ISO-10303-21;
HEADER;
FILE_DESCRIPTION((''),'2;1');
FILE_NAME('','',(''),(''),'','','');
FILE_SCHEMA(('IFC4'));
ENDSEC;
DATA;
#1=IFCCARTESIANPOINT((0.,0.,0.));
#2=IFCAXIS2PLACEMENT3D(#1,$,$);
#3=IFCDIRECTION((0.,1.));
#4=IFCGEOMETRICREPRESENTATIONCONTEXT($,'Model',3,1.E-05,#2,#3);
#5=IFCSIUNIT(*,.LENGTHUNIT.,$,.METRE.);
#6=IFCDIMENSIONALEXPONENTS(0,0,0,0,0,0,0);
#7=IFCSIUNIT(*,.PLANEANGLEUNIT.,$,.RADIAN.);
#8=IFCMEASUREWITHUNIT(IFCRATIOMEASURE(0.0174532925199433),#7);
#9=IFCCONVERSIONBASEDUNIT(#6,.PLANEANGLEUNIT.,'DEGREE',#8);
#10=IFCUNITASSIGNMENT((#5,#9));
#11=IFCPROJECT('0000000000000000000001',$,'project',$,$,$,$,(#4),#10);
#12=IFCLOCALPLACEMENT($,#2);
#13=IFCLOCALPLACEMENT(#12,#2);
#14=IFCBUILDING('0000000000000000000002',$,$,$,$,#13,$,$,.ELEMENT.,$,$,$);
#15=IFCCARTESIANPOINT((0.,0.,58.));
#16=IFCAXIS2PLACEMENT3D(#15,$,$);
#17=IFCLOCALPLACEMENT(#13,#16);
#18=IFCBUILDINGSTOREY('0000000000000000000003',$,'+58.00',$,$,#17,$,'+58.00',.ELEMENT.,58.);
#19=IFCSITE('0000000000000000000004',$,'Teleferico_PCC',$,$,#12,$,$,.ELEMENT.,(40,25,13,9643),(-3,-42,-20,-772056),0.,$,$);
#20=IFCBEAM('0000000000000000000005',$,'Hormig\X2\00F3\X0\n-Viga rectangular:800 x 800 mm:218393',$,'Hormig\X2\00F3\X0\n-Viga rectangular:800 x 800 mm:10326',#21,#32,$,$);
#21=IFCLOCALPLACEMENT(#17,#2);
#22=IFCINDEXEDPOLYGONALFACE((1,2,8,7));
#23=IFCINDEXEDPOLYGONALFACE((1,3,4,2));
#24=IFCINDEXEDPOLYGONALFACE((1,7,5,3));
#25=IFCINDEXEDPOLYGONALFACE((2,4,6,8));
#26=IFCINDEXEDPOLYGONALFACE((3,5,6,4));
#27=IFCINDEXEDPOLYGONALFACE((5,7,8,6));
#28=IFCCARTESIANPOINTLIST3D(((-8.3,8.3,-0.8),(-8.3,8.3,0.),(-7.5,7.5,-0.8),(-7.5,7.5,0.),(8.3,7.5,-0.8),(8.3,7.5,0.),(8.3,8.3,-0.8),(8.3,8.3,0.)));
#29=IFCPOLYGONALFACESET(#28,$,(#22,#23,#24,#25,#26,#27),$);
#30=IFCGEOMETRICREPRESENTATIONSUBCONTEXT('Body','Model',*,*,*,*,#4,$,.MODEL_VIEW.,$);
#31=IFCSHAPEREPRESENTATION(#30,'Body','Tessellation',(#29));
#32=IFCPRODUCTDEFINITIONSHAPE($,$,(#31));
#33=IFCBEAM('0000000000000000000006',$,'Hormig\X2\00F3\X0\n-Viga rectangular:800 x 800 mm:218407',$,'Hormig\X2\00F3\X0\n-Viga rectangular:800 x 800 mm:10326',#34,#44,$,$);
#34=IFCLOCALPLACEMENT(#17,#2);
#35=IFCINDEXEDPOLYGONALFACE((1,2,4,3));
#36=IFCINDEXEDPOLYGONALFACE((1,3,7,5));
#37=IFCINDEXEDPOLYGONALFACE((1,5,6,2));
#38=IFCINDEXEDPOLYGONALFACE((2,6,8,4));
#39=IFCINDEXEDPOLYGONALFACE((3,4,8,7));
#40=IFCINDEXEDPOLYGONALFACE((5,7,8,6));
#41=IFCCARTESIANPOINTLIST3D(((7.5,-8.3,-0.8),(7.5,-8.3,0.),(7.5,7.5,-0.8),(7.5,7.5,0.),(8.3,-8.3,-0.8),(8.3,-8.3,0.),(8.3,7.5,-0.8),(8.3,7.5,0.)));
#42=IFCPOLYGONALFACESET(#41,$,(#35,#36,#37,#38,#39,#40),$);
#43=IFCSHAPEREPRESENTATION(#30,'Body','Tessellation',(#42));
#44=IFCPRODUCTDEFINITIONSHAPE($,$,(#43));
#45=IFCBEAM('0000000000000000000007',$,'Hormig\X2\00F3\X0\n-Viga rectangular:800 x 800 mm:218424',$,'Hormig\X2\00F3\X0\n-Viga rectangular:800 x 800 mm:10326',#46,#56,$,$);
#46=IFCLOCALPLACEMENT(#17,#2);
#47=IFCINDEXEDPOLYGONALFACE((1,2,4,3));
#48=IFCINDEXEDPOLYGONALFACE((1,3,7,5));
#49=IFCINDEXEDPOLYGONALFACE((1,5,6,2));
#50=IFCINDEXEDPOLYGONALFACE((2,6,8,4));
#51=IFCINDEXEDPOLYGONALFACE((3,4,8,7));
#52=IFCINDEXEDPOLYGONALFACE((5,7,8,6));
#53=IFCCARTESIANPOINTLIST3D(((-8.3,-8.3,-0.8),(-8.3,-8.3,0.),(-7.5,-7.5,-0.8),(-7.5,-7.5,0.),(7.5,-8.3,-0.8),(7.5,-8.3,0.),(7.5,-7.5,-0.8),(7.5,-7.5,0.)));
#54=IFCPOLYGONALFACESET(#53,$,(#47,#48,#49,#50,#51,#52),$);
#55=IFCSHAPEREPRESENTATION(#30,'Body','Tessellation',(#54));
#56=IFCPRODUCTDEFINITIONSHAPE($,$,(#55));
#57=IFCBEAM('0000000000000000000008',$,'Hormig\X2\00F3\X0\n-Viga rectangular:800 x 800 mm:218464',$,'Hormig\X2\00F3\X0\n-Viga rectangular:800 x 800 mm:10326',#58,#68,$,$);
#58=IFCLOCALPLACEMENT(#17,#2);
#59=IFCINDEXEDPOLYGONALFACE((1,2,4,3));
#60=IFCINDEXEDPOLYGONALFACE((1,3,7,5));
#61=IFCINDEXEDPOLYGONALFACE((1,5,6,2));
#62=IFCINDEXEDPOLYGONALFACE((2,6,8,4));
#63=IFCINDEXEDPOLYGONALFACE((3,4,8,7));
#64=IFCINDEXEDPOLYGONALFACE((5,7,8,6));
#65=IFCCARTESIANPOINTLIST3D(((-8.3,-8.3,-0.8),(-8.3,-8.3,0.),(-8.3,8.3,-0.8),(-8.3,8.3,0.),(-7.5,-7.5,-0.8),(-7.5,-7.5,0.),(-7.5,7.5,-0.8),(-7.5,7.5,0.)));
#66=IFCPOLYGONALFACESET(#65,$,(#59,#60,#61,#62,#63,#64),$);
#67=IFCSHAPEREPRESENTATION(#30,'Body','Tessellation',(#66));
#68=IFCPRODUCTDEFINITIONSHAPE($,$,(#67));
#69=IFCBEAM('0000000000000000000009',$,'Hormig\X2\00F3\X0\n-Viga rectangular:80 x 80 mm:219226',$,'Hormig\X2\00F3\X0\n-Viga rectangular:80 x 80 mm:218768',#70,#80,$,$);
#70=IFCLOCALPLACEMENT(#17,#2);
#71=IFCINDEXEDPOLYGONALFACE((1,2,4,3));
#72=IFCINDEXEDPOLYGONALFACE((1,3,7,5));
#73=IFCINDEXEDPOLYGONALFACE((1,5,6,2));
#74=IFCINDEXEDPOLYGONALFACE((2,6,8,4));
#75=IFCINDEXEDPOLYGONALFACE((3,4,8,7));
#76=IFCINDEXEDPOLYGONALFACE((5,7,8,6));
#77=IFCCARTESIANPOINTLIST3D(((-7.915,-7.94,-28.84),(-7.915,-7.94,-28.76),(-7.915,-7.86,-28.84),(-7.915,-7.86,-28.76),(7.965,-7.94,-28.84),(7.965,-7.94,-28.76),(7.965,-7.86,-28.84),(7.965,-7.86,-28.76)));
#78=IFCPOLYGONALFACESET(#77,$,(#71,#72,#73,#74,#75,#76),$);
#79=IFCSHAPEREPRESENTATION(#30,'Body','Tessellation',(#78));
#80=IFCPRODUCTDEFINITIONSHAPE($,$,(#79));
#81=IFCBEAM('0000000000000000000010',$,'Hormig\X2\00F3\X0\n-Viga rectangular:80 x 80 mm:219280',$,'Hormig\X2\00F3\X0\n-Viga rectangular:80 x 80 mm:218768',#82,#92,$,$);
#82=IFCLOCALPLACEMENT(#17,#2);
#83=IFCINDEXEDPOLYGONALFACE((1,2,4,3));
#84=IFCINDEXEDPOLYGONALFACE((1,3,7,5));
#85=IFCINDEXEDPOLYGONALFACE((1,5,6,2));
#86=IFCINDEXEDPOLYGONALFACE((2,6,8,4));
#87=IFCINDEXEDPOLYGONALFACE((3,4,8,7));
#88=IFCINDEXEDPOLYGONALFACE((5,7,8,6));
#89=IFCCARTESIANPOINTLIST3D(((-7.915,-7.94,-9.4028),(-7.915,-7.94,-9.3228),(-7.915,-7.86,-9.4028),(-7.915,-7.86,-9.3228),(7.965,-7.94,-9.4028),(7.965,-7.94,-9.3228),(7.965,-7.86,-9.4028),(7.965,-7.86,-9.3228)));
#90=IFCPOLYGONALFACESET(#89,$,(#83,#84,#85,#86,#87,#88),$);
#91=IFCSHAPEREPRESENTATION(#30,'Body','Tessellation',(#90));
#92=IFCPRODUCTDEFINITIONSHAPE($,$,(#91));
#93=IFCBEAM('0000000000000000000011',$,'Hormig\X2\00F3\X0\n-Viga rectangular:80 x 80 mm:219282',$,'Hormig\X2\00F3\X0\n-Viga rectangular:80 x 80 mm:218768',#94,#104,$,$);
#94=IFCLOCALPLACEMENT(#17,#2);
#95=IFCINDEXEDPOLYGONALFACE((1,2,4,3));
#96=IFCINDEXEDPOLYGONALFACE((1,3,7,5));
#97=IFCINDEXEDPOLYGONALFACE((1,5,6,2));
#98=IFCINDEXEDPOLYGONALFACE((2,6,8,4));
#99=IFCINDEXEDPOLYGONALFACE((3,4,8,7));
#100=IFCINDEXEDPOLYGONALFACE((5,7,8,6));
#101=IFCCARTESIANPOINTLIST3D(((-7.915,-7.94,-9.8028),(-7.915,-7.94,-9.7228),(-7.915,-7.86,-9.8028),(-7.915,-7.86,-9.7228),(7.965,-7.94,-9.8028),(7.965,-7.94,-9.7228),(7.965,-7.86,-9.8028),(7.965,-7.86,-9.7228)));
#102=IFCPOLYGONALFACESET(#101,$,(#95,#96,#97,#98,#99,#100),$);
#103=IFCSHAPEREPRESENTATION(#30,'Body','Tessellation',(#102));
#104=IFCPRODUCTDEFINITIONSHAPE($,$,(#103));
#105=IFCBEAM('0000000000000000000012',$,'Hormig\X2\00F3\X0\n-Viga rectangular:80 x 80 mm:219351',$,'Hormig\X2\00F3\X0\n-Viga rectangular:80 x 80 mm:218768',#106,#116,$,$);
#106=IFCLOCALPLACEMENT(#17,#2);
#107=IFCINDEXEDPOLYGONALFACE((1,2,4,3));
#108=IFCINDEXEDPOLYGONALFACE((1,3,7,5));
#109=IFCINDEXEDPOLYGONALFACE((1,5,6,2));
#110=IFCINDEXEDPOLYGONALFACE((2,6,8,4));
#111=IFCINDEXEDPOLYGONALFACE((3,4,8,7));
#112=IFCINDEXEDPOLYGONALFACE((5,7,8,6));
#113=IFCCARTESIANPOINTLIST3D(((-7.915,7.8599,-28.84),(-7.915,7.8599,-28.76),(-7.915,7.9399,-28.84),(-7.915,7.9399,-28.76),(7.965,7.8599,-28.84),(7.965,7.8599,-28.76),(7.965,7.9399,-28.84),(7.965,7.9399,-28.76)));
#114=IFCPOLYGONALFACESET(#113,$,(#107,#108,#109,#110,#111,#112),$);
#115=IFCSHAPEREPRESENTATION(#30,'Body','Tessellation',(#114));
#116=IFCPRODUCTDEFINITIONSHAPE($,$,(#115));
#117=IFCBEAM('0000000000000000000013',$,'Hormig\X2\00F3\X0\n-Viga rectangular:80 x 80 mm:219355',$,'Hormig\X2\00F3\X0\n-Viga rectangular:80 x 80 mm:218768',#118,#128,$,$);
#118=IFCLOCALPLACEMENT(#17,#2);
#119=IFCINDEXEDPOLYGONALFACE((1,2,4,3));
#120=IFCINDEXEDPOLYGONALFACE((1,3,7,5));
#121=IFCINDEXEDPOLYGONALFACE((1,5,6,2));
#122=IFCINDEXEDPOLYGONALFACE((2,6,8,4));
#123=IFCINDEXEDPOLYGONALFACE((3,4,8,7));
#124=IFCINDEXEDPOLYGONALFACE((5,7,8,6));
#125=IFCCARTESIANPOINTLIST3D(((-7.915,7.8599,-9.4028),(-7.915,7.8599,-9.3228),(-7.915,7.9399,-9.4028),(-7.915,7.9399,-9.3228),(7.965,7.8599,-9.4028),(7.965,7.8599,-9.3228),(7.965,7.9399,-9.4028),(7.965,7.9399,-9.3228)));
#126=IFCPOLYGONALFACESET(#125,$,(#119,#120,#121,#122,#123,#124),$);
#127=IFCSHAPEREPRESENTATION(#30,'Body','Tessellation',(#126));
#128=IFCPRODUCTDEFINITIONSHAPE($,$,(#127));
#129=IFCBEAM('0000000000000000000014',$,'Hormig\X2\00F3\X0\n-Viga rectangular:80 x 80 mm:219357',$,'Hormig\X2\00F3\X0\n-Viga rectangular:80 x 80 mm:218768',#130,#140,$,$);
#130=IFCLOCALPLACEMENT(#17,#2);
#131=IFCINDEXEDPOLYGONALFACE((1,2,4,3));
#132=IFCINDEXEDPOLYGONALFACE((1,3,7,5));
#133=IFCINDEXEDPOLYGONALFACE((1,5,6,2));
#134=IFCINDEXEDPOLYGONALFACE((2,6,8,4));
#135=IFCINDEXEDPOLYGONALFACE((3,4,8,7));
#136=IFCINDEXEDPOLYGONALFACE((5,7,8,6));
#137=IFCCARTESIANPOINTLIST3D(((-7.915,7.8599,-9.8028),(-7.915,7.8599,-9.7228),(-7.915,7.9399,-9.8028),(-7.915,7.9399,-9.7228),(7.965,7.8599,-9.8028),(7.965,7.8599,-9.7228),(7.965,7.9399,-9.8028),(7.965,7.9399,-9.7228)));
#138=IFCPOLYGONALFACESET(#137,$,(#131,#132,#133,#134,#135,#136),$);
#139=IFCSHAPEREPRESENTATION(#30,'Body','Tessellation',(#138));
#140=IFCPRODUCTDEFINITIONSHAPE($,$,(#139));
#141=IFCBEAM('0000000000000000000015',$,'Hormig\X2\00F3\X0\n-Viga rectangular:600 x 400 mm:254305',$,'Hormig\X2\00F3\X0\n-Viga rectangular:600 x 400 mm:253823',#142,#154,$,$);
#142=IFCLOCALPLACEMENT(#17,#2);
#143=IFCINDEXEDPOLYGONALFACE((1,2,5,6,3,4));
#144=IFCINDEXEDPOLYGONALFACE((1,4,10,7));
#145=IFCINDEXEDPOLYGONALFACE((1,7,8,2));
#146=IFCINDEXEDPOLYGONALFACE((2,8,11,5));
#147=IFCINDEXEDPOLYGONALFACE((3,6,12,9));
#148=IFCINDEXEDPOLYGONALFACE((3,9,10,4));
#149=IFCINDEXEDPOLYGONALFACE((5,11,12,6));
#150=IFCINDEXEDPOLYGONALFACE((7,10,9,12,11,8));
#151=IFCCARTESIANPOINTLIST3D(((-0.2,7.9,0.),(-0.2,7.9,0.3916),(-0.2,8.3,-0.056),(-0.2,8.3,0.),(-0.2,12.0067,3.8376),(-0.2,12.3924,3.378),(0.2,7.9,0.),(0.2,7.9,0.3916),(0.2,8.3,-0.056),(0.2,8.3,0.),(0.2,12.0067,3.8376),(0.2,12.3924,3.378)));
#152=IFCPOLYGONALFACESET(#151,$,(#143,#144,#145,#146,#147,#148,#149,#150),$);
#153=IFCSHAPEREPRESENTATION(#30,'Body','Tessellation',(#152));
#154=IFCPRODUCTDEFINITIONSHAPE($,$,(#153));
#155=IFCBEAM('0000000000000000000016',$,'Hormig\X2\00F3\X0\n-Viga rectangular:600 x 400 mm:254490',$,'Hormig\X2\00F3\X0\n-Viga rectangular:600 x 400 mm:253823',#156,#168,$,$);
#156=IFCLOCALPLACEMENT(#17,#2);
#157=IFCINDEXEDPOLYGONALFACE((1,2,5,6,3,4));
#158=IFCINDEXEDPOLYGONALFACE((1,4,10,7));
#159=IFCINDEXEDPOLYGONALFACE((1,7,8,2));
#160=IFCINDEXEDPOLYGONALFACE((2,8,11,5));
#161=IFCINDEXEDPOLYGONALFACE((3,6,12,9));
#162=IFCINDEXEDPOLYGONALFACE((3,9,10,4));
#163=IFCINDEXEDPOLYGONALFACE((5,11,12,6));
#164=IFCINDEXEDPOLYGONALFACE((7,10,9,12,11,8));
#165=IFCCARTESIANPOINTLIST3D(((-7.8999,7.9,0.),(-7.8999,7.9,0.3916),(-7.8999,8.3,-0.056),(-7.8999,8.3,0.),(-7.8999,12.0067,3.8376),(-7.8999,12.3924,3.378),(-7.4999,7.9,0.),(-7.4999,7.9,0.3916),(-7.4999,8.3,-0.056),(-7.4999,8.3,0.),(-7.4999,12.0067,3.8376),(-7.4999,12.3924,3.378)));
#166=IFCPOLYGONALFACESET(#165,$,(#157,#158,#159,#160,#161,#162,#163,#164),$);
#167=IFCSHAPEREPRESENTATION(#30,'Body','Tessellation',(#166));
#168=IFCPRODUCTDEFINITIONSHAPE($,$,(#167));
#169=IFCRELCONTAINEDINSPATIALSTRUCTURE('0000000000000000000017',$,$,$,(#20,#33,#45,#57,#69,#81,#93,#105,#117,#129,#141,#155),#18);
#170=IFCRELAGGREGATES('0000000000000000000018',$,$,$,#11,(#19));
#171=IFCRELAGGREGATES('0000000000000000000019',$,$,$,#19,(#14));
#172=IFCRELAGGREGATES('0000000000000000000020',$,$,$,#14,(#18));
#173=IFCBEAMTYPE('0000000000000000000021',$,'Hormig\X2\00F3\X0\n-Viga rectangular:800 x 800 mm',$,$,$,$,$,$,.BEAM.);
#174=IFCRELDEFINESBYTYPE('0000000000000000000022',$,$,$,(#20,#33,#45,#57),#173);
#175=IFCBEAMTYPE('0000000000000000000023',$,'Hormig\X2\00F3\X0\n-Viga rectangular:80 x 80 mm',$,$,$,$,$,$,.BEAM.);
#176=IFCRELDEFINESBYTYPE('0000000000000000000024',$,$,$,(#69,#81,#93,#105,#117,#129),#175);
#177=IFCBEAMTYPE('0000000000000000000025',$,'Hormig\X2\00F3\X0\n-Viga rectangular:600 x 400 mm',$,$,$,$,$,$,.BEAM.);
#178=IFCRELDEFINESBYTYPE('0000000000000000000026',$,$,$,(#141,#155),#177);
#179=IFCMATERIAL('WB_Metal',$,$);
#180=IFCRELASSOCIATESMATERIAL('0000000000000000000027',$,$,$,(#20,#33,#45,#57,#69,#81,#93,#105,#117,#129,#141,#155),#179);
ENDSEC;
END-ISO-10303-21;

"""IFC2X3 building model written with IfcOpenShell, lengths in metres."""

from ifc_helpers import new_model, entity, si_unit, converted_unit, direction, frame, frame_2d, origin, place, context, subcontext, project, spatial, polyline, rectangle, extrude, clip, halfspace, bounded_halfspace, material, type_object, element, save


model = new_model("IFC2X3")

# Units and contexts
model_context = context("Model", 3, precision=1e-05, world=origin(), true_north=direction((0.0, 1.0)))
body_context = subcontext(model_context, "Body", "Model", "MODEL_VIEW")
ifc_project = project(units=[si_unit("LENGTHUNIT", "METRE"), converted_unit("PLANEANGLEUNIT", "DEGREE", entity("IfcRatioMeasure", 0.0174532925199433), si_unit("PLANEANGLEUNIT", "RADIAN"), dimensions=[0, 0, 0, 0, 0, 0, 0])], contexts=[model_context])

# Site, building, storey
site_placement = place(None, origin())
site = spatial("IfcSite", under=ifc_project, at=site_placement, Name="Teleferico_PCC", CompositionType="ELEMENT", RefLatitude=(40, 25, 13, 9643), RefLongitude=(-3, -42, -20, -772056), RefElevation=0.0)
building_placement = place(site_placement, origin())
building = spatial("IfcBuilding", under=site, at=building_placement, CompositionType="ELEMENT")
storey_placement = place(building_placement, frame((0.0, 0.0, 58.0)))
storey = spatial("IfcBuildingStorey", under=building, at=storey_placement, Name="+58.00", LongName="+58.00", CompositionType="ELEMENT", Elevation=58.0)

# Beams
ifc_material = material(Name="WB_Metal")
beam_type_1 = type_object("IfcBeamType", Name="Hormigón-Viga rectangular:800 x 800 mm", PredefinedType="BEAM")
beam_1_placement = place(storey_placement, frame((-7.9, 7.9, 0.0)))
element("IfcBeam", 1, at=beam_1_placement, inside=storey, type_object=beam_type_1, material=ifc_material, Name="Hormigón-Viga rectangular:800 x 800 mm:218393", ObjectType="Hormigón-Viga rectangular:800 x 800 mm:10326", context=body_context, shape_type="Clipping", body=[
    clip(extrude(rectangle(XDim=0.8, YDim=0.8, at=frame_2d((0.0, 0.0), x_axis=(1.0, 0.0))), frame((-0.4, 0.0, -0.4), z_axis=(1.0, 0.0, 0.0), x_axis=(0.0, 0.0, -1.0)), (0.0, 0.0, 1.0), 16.6), halfspace(frame((0.4, -0.4, 0.0), z_axis=(-0.707107, -0.707107, 0.0), x_axis=(0.707107, -0.707107, 0.0)), False)),
])
beam_2_placement = place(storey_placement, frame((7.9, 7.9, 0.0), z_axis=(0.0, 0.0, 1.0), x_axis=(0.0, -1.0, 0.0)))
element("IfcBeam", 2, at=beam_2_placement, inside=storey, type_object=beam_type_1, material=ifc_material, Name="Hormigón-Viga rectangular:800 x 800 mm:218407", ObjectType="Hormigón-Viga rectangular:800 x 800 mm:10326", context=body_context, shape_type="SweptSolid", body=[
    extrude(rectangle(XDim=0.8, YDim=0.8, at=frame_2d((0.0, 0.0), x_axis=(1.0, 0.0))), frame((0.4, 0.0, -0.4), z_axis=(1.0, 0.0, 0.0), x_axis=(0.0, 0.0, -1.0)), (0.0, 0.0, 1.0), 15.8),
])
beam_3_placement = place(storey_placement, frame((7.9, -7.9, 0.0), z_axis=(0.0, 0.0, 1.0), x_axis=(-1.0, 0.0, 0.0)))
element("IfcBeam", 3, at=beam_3_placement, inside=storey, type_object=beam_type_1, material=ifc_material, Name="Hormigón-Viga rectangular:800 x 800 mm:218424", ObjectType="Hormigón-Viga rectangular:800 x 800 mm:10326", context=body_context, shape_type="Clipping", body=[
    clip(extrude(rectangle(XDim=0.8, YDim=0.8, at=frame_2d((0.0, 0.0), x_axis=(1.0, 0.0))), frame((0.4, 0.0, -0.4), z_axis=(1.0, 0.0, 0.0), x_axis=(0.0, 0.0, -1.0)), (0.0, 0.0, 1.0), 15.8), halfspace(frame((15.4, -0.4, 0.0), z_axis=(0.707107, -0.707107, 0.0), x_axis=(-0.707107, -0.707107, 0.0)), False)),
])
beam_4_placement = place(storey_placement, frame((-7.9, -7.9, 0.0), z_axis=(0.0, 0.0, 1.0), x_axis=(0.0, 1.0, 0.0)))
element("IfcBeam", 4, at=beam_4_placement, inside=storey, type_object=beam_type_1, material=ifc_material, Name="Hormigón-Viga rectangular:800 x 800 mm:218464", ObjectType="Hormigón-Viga rectangular:800 x 800 mm:10326", context=body_context, shape_type="Clipping", body=[
    clip(clip(extrude(rectangle(XDim=0.8, YDim=0.8, at=frame_2d((0.0, 0.0), x_axis=(1.0, 0.0))), frame((-0.4, 0.0, -0.4), z_axis=(1.0, 0.0, 0.0), x_axis=(0.0, 0.0, -1.0)), (0.0, 0.0, 1.0), 16.6), halfspace(frame((0.4, -0.4, 0.0), z_axis=(-0.707107, -0.707107, 0.0), x_axis=(0.707107, -0.707107, 0.0)), False)), halfspace(frame((15.4, -0.4, 0.0), z_axis=(0.707107, -0.707107, 0.0), x_axis=(-0.707107, -0.707107, 0.0)), False)),
])
beam_type_2 = type_object("IfcBeamType", Name="Hormigón-Viga rectangular:80 x 80 mm", PredefinedType="BEAM")
beam_5_placement = place(storey_placement, frame((-7.875, -7.9, -28.8)))
element("IfcBeam", 5, at=beam_5_placement, inside=storey, type_object=beam_type_2, material=ifc_material, Name="Hormigón-Viga rectangular:80 x 80 mm:219226", ObjectType="Hormigón-Viga rectangular:80 x 80 mm:218768", context=body_context, shape_type="SweptSolid", body=[
    extrude(rectangle(XDim=0.08, YDim=0.08, at=frame_2d((0.0, 0.0), x_axis=(1.0, 0.0))), frame((-0.04, 0.0, 0.0), z_axis=(1.0, 0.0, 0.0), x_axis=(0.0, 0.0, -1.0)), (0.0, 0.0, 1.0), 15.88),
])
beam_6_placement = place(storey_placement, frame((-7.875, -7.9, -9.3628)))
element("IfcBeam", 6, at=beam_6_placement, inside=storey, type_object=beam_type_2, material=ifc_material, Name="Hormigón-Viga rectangular:80 x 80 mm:219280", ObjectType="Hormigón-Viga rectangular:80 x 80 mm:218768", context=body_context, shape_type="SweptSolid", body=[
    extrude(rectangle(XDim=0.08, YDim=0.08, at=frame_2d((0.0, 0.0), x_axis=(1.0, 0.0))), frame((-0.04, 0.0, 0.0), z_axis=(1.0, 0.0, 0.0), x_axis=(0.0, 0.0, -1.0)), (0.0, 0.0, 1.0), 15.88),
])
beam_7_placement = place(storey_placement, frame((-7.875, -7.9, -9.7628)))
element("IfcBeam", 7, at=beam_7_placement, inside=storey, type_object=beam_type_2, material=ifc_material, Name="Hormigón-Viga rectangular:80 x 80 mm:219282", ObjectType="Hormigón-Viga rectangular:80 x 80 mm:218768", context=body_context, shape_type="SweptSolid", body=[
    extrude(rectangle(XDim=0.08, YDim=0.08, at=frame_2d((0.0, 0.0), x_axis=(1.0, 0.0))), frame((-0.04, 0.0, 0.0), z_axis=(1.0, 0.0, 0.0), x_axis=(0.0, 0.0, -1.0)), (0.0, 0.0, 1.0), 15.88),
])
beam_8_placement = place(storey_placement, frame((-7.875, 7.8999, -28.8)))
element("IfcBeam", 8, at=beam_8_placement, inside=storey, type_object=beam_type_2, material=ifc_material, Name="Hormigón-Viga rectangular:80 x 80 mm:219351", ObjectType="Hormigón-Viga rectangular:80 x 80 mm:218768", context=body_context, shape_type="SweptSolid", body=[
    extrude(rectangle(XDim=0.08, YDim=0.08, at=frame_2d((0.0, 0.0), x_axis=(1.0, 0.0))), frame((-0.04, 0.0, 0.0), z_axis=(1.0, 0.0, 0.0), x_axis=(0.0, 0.0, -1.0)), (0.0, 0.0, 1.0), 15.88),
])
for number, where, name in (
    (9, (-7.875, 7.8999, -9.3628), "Hormigón-Viga rectangular:80 x 80 mm:219355"),
    (10, (-7.875, 7.8999, -9.7628), "Hormigón-Viga rectangular:80 x 80 mm:219357"),
):
    element("IfcBeam", number, at=place(storey_placement, frame(where)), inside=storey, type_object=beam_type_2, material=ifc_material, Name=name, ObjectType="Hormigón-Viga rectangular:80 x 80 mm:218768", context=body_context, shape_type="SweptSolid", body=[
        extrude(rectangle(XDim=0.08, YDim=0.08, at=frame_2d((0.0, 0.0), x_axis=(1.0, 0.0))), frame((-0.04, 0.0, 0.0), z_axis=(1.0, 0.0, 0.0), x_axis=(0.0, 0.0, -1.0)), (0.0, 0.0, 1.0), 15.88),
    ])
beam_type_3 = type_object("IfcBeamType", Name="Hormigón-Viga rectangular:600 x 400 mm", PredefinedType="BEAM")
beam_9_placement = place(storey_placement, frame((0.0, 7.9, 0.0), z_axis=(0.0, -0.642788, 0.766044), x_axis=(0.0, 0.766044, 0.642788)))
element("IfcBeam", 11, at=beam_9_placement, inside=storey, type_object=beam_type_3, material=ifc_material, Name="Hormigón-Viga rectangular:600 x 400 mm:254305", ObjectType="Hormigón-Viga rectangular:600 x 400 mm:253823", context=body_context, shape_type="Clipping", body=[
    clip(clip(clip(extrude(rectangle(XDim=0.6, YDim=0.4, at=frame_2d((0.0, 0.0), x_axis=(0.0, 1.0))), frame((0.0, 0.0, 0.0), z_axis=(1.0, 0.0, 0.0), x_axis=(0.0, 1.0, 0.0)), (0.0, 0.0, 1.0), 5.6127), halfspace(frame((0.0, 7.9, 0.0), z_axis=(-0.766044, 0.0, 0.642788), x_axis=(0.642788, 0.0, 0.766044)), False)), bounded_halfspace(frame((0.3064, -7.5, -0.2571), z_axis=(-0.642788, 0.0, -0.766044), x_axis=(0.0, 1.0, 0.0)), False, frame((0.0, 0.0, 0.0), z_axis=(1.0, 0.0, 0.0), x_axis=(0.0, 1.0, 0.0)), polyline([(0.2, -0.2571), (-0.2, -0.2571), (-0.2, 0.0), (0.2, 0.0), (0.2, -0.2571)]))), bounded_halfspace(frame((-0.2078, -7.5, -0.87), z_axis=(-0.766044, 0.0, 0.642788), x_axis=(0.0, 1.0, 0.0)), False, frame((0.0, 0.0, 0.0), z_axis=(1.0, 0.0, 0.0), x_axis=(0.0, 1.0, 0.0)), polyline([(-0.2, -0.2571), (0.2, -0.2571), (0.2, -0.3), (-0.2, -0.3), (-0.2, -0.2571)]))),
])
beam_10_placement = place(storey_placement, frame((-7.6999, 7.9, 0.0), z_axis=(0.0, -0.642788, 0.766044), x_axis=(0.0, 0.766044, 0.642788)))
element("IfcBeam", 12, at=beam_10_placement, inside=storey, type_object=beam_type_3, material=ifc_material, Name="Hormigón-Viga rectangular:600 x 400 mm:254490", ObjectType="Hormigón-Viga rectangular:600 x 400 mm:253823", context=body_context, shape_type="Clipping", body=[
    clip(clip(clip(extrude(rectangle(XDim=0.6, YDim=0.4, at=frame_2d((0.0, 0.0), x_axis=(0.0, 1.0))), frame((0.0, 0.0, 0.0), z_axis=(1.0, 0.0, 0.0), x_axis=(0.0, 1.0, 0.0)), (0.0, 0.0, 1.0), 5.6127), halfspace(frame((0.0, 0.2, 0.0), z_axis=(-0.766044, 0.0, 0.642788), x_axis=(0.642788, 0.0, 0.766044)), False)), bounded_halfspace(frame((0.3064, -15.1999, -0.2571), z_axis=(-0.642788, 0.0, -0.766044), x_axis=(0.0, 1.0, 0.0)), False, frame((0.0, 0.0, 0.0), z_axis=(1.0, 0.0, 0.0), x_axis=(0.0, 1.0, 0.0)), polyline([(-0.2, -0.2571), (-0.2, 0.0), (0.2, 0.0), (0.2, -0.2571), (-0.2, -0.2571)]))), bounded_halfspace(frame((-0.2078, -15.1999, -0.87), z_axis=(-0.766044, 0.0, 0.642788), x_axis=(0.0, 1.0, 0.0)), False, frame((0.0, 0.0, 0.0), z_axis=(1.0, 0.0, 0.0), x_axis=(0.0, 1.0, 0.0)), polyline([(-0.2, -0.3), (-0.2, -0.2571), (0.2, -0.2571), (0.2, -0.3), (-0.2, -0.3)]))),
])

save(model, "model.ifc")
